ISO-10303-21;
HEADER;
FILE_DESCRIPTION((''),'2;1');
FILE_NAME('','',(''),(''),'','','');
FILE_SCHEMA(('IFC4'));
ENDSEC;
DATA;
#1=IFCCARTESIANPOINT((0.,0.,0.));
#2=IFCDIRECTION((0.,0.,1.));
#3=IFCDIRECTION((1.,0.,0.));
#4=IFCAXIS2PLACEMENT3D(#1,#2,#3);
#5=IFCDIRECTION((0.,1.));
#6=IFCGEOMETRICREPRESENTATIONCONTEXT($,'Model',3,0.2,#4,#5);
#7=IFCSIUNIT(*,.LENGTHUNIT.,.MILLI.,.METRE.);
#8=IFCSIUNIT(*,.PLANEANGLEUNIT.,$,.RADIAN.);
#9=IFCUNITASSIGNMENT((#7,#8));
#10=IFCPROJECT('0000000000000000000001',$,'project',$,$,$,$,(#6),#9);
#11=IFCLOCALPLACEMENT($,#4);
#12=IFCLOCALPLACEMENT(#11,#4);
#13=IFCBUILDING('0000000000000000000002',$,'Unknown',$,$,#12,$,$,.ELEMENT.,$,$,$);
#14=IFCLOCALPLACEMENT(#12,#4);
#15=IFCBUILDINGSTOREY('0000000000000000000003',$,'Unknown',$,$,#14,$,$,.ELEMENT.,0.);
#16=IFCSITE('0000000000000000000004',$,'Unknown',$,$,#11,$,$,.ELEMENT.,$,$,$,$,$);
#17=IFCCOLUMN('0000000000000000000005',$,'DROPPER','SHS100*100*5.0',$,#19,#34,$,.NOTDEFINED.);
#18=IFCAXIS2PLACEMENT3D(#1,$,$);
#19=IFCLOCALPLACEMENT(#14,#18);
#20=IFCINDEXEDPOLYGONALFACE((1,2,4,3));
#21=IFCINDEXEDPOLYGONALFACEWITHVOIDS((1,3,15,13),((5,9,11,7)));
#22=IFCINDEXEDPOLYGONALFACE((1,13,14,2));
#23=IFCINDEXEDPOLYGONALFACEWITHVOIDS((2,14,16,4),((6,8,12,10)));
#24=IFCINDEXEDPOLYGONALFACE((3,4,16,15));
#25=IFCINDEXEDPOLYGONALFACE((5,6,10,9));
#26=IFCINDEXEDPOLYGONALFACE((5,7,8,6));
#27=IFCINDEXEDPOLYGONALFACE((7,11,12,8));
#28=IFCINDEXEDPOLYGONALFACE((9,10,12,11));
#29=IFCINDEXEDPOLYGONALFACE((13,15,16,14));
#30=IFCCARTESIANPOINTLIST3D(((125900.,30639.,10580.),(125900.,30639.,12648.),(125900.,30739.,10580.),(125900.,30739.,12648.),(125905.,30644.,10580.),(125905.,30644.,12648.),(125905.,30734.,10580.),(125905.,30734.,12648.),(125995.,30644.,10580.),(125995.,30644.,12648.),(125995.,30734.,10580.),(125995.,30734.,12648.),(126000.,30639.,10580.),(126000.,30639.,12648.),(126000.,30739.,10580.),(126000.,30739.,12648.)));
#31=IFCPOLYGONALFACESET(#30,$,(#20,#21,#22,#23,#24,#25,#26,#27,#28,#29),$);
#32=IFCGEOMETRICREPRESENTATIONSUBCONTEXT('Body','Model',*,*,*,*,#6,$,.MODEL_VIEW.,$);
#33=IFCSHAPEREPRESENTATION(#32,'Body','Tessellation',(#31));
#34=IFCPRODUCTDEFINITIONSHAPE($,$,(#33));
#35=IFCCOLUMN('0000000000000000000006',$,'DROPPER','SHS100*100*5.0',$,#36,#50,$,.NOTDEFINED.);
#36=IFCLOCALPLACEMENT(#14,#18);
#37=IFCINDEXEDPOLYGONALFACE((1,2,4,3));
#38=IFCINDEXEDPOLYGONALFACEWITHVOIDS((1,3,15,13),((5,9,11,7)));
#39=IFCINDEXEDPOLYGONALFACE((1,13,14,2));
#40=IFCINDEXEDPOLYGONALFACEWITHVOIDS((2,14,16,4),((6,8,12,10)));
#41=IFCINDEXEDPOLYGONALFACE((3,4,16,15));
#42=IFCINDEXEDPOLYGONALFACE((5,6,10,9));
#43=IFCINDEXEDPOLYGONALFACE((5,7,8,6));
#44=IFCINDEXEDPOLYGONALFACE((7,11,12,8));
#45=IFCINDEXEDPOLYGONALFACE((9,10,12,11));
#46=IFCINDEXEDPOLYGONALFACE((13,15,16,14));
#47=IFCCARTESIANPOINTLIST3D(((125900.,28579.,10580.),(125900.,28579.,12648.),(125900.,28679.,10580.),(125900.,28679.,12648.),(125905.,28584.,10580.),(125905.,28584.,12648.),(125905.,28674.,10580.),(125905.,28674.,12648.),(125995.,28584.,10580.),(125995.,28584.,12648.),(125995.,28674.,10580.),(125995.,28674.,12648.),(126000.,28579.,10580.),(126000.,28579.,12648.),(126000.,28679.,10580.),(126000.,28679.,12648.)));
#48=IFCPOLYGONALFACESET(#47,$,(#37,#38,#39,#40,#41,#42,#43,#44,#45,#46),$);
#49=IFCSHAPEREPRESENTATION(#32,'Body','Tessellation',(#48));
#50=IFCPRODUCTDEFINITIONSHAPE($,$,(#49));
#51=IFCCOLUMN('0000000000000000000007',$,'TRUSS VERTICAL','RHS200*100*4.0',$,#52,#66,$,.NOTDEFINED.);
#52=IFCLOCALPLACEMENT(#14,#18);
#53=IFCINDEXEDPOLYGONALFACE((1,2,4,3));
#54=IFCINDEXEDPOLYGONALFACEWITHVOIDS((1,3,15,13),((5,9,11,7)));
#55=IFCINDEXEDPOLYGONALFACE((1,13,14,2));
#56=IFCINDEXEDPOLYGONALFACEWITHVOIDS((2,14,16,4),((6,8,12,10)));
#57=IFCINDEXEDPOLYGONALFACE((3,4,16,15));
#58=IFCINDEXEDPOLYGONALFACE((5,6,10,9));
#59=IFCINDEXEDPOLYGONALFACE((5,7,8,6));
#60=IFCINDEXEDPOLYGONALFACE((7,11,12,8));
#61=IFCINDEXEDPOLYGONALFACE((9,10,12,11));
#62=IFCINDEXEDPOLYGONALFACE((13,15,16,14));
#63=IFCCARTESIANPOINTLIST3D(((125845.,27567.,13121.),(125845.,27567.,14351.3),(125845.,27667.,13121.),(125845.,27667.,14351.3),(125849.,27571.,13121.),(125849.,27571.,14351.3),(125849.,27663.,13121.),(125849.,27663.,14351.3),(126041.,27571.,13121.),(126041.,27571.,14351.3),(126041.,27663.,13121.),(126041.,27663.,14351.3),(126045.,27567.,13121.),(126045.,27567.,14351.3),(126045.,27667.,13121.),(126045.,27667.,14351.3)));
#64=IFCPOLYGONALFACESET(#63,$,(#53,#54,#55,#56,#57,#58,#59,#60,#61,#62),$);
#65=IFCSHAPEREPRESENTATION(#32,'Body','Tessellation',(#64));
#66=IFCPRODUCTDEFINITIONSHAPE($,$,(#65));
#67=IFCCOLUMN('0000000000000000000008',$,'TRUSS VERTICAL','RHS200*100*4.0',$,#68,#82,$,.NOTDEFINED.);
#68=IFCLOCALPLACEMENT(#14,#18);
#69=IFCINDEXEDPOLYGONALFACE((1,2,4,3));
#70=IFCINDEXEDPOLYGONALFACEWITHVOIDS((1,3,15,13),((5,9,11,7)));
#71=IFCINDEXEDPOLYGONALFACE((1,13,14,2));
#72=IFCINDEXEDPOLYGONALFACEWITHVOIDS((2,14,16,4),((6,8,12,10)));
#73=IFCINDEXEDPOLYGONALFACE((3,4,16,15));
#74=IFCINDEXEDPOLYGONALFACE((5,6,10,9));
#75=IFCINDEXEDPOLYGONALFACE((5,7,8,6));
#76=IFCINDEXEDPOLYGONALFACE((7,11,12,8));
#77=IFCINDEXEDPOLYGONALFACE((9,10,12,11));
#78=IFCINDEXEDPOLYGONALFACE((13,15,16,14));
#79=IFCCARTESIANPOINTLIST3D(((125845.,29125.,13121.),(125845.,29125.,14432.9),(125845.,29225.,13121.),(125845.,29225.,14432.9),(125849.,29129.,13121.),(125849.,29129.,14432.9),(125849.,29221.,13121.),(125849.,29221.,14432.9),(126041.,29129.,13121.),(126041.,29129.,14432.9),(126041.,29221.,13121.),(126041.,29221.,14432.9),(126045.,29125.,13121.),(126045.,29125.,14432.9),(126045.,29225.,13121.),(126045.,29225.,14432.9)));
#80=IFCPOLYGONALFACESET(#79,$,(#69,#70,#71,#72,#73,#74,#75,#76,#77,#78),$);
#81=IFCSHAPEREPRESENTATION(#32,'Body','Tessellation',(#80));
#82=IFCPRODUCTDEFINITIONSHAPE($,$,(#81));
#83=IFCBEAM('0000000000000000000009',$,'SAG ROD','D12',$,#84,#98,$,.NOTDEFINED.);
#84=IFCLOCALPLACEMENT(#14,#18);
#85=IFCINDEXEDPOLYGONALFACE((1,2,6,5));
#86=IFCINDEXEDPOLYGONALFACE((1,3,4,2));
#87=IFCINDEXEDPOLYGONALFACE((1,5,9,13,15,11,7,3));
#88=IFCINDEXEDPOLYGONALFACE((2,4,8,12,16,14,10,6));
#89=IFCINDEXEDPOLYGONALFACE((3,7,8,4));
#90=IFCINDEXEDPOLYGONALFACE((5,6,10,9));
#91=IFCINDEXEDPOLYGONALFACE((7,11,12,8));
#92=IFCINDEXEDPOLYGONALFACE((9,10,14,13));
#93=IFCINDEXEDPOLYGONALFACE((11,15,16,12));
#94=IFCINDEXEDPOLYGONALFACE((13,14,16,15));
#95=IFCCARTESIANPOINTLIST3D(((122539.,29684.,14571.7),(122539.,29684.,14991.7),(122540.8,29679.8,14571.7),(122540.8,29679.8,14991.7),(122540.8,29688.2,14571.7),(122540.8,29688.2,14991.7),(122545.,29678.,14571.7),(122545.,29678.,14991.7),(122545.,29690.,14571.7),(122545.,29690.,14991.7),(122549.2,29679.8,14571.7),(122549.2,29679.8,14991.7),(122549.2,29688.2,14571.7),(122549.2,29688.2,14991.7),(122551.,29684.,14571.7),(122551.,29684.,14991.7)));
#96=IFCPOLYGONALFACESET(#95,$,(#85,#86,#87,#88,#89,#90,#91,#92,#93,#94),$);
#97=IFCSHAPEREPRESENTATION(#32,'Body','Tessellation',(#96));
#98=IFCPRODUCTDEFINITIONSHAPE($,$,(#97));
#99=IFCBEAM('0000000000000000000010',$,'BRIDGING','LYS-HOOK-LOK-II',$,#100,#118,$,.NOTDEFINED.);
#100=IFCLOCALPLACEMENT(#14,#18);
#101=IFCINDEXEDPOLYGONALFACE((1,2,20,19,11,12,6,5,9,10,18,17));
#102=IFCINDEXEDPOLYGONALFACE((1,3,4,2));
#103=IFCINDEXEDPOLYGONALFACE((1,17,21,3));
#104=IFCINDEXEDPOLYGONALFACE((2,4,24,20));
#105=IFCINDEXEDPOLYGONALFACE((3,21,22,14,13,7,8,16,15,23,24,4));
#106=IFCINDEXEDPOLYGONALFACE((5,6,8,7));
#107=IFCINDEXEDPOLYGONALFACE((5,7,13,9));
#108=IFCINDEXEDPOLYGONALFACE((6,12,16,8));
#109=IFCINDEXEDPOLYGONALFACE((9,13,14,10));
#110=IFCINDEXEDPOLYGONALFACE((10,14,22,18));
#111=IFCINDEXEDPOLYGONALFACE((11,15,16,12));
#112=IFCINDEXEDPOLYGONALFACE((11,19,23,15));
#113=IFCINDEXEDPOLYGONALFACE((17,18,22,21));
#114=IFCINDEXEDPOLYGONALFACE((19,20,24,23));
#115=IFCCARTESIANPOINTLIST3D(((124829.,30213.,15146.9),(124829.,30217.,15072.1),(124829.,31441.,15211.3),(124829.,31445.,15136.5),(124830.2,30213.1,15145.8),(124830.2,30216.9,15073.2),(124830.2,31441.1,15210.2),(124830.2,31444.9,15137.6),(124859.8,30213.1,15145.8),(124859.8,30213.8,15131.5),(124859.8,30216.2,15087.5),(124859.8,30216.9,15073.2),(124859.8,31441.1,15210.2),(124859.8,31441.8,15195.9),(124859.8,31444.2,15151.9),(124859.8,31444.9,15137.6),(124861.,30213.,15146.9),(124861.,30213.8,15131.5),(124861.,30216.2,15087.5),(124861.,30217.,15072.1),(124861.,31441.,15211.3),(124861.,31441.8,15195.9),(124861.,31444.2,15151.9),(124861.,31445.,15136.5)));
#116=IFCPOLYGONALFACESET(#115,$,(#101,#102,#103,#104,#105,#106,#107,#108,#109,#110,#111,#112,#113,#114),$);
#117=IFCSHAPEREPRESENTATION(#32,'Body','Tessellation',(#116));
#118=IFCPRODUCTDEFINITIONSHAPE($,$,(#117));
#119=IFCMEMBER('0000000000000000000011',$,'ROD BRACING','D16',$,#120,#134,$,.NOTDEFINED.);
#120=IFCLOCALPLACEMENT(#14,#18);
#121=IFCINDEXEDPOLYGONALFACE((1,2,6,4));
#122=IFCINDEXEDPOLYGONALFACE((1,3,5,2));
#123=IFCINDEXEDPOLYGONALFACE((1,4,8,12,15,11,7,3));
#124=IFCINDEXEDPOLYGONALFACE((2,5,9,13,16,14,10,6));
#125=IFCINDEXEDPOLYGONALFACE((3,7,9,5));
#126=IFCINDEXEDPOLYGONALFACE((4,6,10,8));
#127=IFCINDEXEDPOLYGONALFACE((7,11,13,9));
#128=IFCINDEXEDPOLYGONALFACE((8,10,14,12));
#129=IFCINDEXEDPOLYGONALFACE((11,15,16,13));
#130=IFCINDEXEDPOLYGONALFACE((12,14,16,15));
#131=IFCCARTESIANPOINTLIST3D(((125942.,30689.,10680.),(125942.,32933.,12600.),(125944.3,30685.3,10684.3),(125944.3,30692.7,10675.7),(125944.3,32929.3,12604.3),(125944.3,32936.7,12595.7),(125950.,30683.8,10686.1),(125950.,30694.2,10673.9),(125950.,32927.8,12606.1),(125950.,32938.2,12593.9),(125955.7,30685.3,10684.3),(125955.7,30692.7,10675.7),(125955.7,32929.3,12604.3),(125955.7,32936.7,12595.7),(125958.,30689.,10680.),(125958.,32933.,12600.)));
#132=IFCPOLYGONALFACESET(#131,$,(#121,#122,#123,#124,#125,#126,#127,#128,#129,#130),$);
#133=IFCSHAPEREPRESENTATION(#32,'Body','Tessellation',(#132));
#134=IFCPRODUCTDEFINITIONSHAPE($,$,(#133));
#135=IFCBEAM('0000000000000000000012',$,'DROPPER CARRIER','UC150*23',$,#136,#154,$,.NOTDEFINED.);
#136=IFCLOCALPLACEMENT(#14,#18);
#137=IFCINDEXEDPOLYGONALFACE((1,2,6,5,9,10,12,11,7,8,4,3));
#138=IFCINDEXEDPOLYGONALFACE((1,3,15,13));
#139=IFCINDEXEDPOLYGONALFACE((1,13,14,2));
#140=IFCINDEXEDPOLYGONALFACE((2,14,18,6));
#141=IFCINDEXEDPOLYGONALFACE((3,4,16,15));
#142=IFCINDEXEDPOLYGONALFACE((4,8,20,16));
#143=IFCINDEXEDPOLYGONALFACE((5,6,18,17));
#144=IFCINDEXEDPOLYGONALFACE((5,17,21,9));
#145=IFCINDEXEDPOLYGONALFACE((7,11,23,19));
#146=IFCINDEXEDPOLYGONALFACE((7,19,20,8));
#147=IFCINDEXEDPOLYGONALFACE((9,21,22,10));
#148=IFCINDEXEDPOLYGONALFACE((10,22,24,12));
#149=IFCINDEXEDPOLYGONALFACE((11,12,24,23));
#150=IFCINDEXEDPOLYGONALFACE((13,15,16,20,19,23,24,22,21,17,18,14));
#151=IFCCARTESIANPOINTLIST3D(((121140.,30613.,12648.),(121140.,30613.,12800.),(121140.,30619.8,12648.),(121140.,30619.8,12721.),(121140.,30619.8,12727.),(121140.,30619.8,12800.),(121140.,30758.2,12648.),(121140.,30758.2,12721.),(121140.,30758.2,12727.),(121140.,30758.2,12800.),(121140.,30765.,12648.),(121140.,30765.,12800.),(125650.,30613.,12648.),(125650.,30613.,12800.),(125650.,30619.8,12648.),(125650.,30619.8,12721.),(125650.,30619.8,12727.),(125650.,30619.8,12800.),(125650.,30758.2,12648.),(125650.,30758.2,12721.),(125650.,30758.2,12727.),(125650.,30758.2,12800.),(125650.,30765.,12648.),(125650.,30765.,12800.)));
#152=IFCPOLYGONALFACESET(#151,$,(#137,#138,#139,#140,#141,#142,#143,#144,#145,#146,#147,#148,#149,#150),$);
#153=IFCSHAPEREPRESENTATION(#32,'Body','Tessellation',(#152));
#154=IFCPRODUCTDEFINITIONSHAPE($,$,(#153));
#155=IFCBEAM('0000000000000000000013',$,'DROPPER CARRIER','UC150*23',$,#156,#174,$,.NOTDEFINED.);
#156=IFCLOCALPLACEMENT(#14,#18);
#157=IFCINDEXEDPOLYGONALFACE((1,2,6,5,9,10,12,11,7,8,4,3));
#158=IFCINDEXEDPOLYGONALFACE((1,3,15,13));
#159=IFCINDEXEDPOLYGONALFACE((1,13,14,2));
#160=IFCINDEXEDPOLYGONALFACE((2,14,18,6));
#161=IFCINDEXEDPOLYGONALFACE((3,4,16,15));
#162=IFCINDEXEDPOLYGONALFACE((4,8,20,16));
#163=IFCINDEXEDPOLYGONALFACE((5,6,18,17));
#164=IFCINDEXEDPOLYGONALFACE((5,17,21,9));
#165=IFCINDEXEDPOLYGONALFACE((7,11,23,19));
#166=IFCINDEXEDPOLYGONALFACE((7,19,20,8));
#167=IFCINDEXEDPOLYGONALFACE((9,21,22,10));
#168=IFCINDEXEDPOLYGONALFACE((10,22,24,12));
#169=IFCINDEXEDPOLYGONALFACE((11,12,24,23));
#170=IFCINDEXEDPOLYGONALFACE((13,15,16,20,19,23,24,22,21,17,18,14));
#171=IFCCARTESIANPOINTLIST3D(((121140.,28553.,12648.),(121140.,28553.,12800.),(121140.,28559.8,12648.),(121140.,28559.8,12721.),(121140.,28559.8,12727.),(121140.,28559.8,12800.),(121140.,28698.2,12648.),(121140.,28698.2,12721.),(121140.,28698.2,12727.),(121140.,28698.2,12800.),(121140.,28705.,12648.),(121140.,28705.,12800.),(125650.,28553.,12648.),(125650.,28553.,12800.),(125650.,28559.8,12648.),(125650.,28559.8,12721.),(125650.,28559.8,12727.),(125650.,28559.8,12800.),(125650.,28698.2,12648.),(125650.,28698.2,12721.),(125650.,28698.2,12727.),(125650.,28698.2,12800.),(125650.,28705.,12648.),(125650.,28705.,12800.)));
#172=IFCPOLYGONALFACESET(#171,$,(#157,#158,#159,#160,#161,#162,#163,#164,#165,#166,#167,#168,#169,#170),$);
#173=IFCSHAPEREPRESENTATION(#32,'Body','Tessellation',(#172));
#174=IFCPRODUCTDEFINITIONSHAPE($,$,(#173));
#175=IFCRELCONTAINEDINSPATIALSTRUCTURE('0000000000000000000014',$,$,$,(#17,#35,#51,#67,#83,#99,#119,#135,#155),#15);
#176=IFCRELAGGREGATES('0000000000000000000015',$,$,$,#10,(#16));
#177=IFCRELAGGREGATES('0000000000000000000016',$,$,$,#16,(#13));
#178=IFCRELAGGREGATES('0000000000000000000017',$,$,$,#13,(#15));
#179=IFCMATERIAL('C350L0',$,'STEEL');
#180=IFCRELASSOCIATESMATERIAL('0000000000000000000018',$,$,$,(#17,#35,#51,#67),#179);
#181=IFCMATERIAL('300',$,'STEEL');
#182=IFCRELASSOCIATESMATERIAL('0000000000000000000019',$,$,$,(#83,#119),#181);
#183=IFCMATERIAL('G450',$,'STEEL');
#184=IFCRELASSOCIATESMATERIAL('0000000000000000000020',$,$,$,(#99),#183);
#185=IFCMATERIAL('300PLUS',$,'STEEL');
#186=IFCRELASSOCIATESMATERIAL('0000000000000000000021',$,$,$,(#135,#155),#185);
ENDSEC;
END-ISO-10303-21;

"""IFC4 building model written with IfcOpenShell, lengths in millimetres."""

from ifc_helpers import new_model, si_unit, direction, frame, origin_with_axes, place, context, subcontext, project, spatial, line, indexed_curve, outline, extrude, material, element, save


model = new_model("IFC4")

# Units and contexts
model_context = context("Model", 3, precision=0.2, world=origin_with_axes(), true_north=direction((0.0, 1.0)))
body_context = subcontext(model_context, "Body", "Model", "MODEL_VIEW")
ifc_project = project(units=[si_unit("LENGTHUNIT", "METRE", prefix="MILLI"), si_unit("PLANEANGLEUNIT", "RADIAN")], contexts=[model_context])

# Site, building, storey
site_placement = place(None, origin_with_axes())
site = spatial("IfcSite", under=ifc_project, at=site_placement, Name="Unknown", CompositionType="ELEMENT")
building_placement = place(site_placement, origin_with_axes())
building = spatial("IfcBuilding", under=site, at=building_placement, Name="Unknown", CompositionType="ELEMENT")
storey_placement = place(building_placement, origin_with_axes())
storey = spatial("IfcBuildingStorey", under=building, at=storey_placement, Name="Unknown", CompositionType="ELEMENT", Elevation=0.0)

# Columns
ifc_material_1 = material(Name="C350L0", Category="STEEL")
for number, where, z_axis, x_axis, name in (
    (1, (125950.0, 30689.0, 10580.0), (-1.0, 0.0, 0.0), (0.0, 0.0, 1.0), "DROPPER"),
    (2, (125950.0, 28629.0, 10580.0), (-1.0, 0.0, 0.0), (0.0, 0.0, 1.0), "DROPPER"),
):
    element("IfcColumn", number, at=place(storey_placement, frame(where, z_axis=z_axis, x_axis=x_axis)), inside=storey, material=ifc_material_1, Name=name, Description="SHS100*100*5.0", PredefinedType="NOTDEFINED", context=body_context, shape_type="SolidModel", body=[
        extrude(outline(indexed_curve([(-50.0, -50.0), (50.0, -50.0), (50.0, 50.0), (-50.0, 50.0)], segments=[line(1, 2, 3, 4, 1)]), holes=[indexed_curve([(-45.0, -45.0), (-45.0, 45.0), (45.0, 45.0), (45.0, -45.0)], segments=[line(1, 2, 3, 4, 1)])]), frame((0.0, 0.0, 0.0), z_axis=(-1.0, 0.0, 0.0), x_axis=(0.0, 0.0, 1.0)), (0.0, 0.0, -1.0), 2068.0),
    ])
column_1_placement = place(storey_placement, frame((125945.0, 27617.0, 13121.0), z_axis=(0.0, -1.0, 0.0), x_axis=(0.0, 0.0, 1.0)))
element("IfcColumn", 3, at=column_1_placement, inside=storey, material=ifc_material_1, Name="TRUSS VERTICAL", Description="RHS200*100*4.0", PredefinedType="NOTDEFINED", context=body_context, shape_type="SolidModel", body=[
    extrude(outline(indexed_curve([(-50.0, -100.0), (50.0, -100.0), (50.0, 100.0), (-50.0, 100.0)], segments=[line(1, 2, 3, 4, 1)]), holes=[indexed_curve([(-46.0, -96.0), (-46.0, 96.0), (46.0, 96.0), (46.0, -96.0)], segments=[line(1, 2, 3, 4, 1)])]), frame((0.0, 0.0, 0.0), z_axis=(-1.0, 0.0, 0.0), x_axis=(0.0, 0.0, 1.0)), (0.0, 0.0, -1.0), 1230.3),
])
column_2_placement = place(storey_placement, frame((125945.0, 29175.0, 13121.0), z_axis=(0.0, -1.0, 0.0), x_axis=(0.0, 0.0, 1.0)))
element("IfcColumn", 4, at=column_2_placement, inside=storey, material=ifc_material_1, Name="TRUSS VERTICAL", Description="RHS200*100*4.0", PredefinedType="NOTDEFINED", context=body_context, shape_type="SolidModel", body=[
    extrude(outline(indexed_curve([(-50.0, -100.0), (50.0, -100.0), (50.0, 100.0), (-50.0, 100.0)], segments=[line(1, 2, 3, 4, 1)]), holes=[indexed_curve([(-46.0, -96.0), (-46.0, 96.0), (46.0, 96.0), (46.0, -96.0)], segments=[line(1, 2, 3, 4, 1)])]), frame((0.0, 0.0, 0.0), z_axis=(-1.0, 0.0, 0.0), x_axis=(0.0, 0.0, 1.0)), (0.0, 0.0, -1.0), 1311.9),
])

# Beams
ifc_material_2 = material(Name="300", Category="STEEL")
beam_1_placement = place(storey_placement, frame((122545.0, 29684.0, 14991.7), z_axis=(1.0, 0.0, 0.0), x_axis=(0.0, 0.0, -1.0)))
element("IfcBeam", 5, at=beam_1_placement, inside=storey, material=ifc_material_2, Name="SAG ROD", Description="D12", PredefinedType="NOTDEFINED", context=body_context, shape_type="SolidModel", body=[
    extrude(outline(indexed_curve([(6.0, 0.0), (4.2, 4.2), (0.0, 6.0), (-4.2, 4.2), (-6.0, 0.0), (-4.2, -4.2), (0.0, -6.0), (4.2, -4.2)], segments=[line(1, 2, 3, 4, 5, 6, 7, 8, 1)])), frame((0.0, 0.0, 0.0), z_axis=(-1.0, 0.0, 0.0), x_axis=(0.0, 0.0, 1.0)), (0.0, 0.0, -1.0), 420.0),
])
ifc_material_3 = material(Name="G450", Category="STEEL")
beam_2_placement = place(storey_placement, frame((124845.0, 30215.0, 15109.5), z_axis=(1.0, 0.0, 0.0), x_axis=(0.0, 0.998628, 0.052371)))
element("IfcBeam", 6, at=beam_2_placement, inside=storey, material=ifc_material_3, Name="BRIDGING", Description="LYS-HOOK-LOK-II", PredefinedType="NOTDEFINED", context=body_context, shape_type="SolidModel", body=[
    extrude(outline(indexed_curve([(16.0, -37.5), (16.0, -22.0), (14.8, -22.0), (14.8, -36.3), (-14.8, -36.3), (-14.8, 36.3), (14.8, 36.3), (14.8, 22.0), (16.0, 22.0), (16.0, 37.5), (-16.0, 37.5), (-16.0, -37.5)], segments=[line(1, 2, 3, 4, 5, 6, 7, 8, 9, 10, 11, 12, 1)])), frame((0.0, 0.0, 0.0), z_axis=(-1.0, 0.0, 0.0), x_axis=(0.0, 0.0, 1.0)), (0.0, 0.0, -1.0), 1229.7),
])

# Member
member_placement = place(storey_placement, frame((125950.0, 30689.0, 10680.0), z_axis=(0.0, -0.650122, 0.75983), x_axis=(0.0, 0.75983, 0.650122)))
element("IfcMember", 7, at=member_placement, inside=storey, material=ifc_material_2, Name="ROD BRACING", Description="D16", PredefinedType="NOTDEFINED", context=body_context, shape_type="SolidModel", body=[
    extrude(outline(indexed_curve([(8.0, 0.0), (5.7, 5.7), (0.0, 8.0), (-5.7, 5.7), (-8.0, 0.0), (-5.7, -5.7), (0.0, -8.0), (5.7, -5.7)], segments=[line(1, 2, 3, 4, 5, 6, 7, 8, 1)])), frame((0.0, 0.0, 0.0), z_axis=(-1.0, 0.0, 0.0), x_axis=(0.0, 0.0, 1.0)), (0.0, 0.0, -1.0), 2953.3),
])

# Beams
ifc_material_4 = material(Name="300PLUS", Category="STEEL")
for number, where, z_axis, x_axis, name in (
    (8, (121140.0, 30689.0, 12724.0), (0.0, 0.0, 1.0), (1.0, 0.0, 0.0), "DROPPER CARRIER"),
    (9, (121140.0, 28629.0, 12724.0), (0.0, 0.0, 1.0), (1.0, 0.0, 0.0), "DROPPER CARRIER"),
):
    element("IfcBeam", number, at=place(storey_placement, frame(where, z_axis=z_axis, x_axis=x_axis)), inside=storey, material=ifc_material_4, Name=name, Description="UC150*23", PredefinedType="NOTDEFINED", context=body_context, shape_type="SolidModel", body=[
        extrude(outline(indexed_curve([(-76.0, -76.0), (76.0, -76.0), (76.0, -69.2), (3.0, -69.2), (3.0, 69.2), (76.0, 69.2), (76.0, 76.0), (-76.0, 76.0), (-76.0, 69.2), (-3.0, 69.2), (-3.0, -69.2), (-76.0, -69.2)], segments=[line(1, 2, 3, 4, 5, 6, 7, 8, 9, 10, 11, 12, 1)])), frame((0.0, 0.0, 0.0), z_axis=(-1.0, 0.0, 0.0), x_axis=(0.0, 0.0, 1.0)), (0.0, 0.0, -1.0), 4510.0),
    ])

save(model, "model.ifc")
